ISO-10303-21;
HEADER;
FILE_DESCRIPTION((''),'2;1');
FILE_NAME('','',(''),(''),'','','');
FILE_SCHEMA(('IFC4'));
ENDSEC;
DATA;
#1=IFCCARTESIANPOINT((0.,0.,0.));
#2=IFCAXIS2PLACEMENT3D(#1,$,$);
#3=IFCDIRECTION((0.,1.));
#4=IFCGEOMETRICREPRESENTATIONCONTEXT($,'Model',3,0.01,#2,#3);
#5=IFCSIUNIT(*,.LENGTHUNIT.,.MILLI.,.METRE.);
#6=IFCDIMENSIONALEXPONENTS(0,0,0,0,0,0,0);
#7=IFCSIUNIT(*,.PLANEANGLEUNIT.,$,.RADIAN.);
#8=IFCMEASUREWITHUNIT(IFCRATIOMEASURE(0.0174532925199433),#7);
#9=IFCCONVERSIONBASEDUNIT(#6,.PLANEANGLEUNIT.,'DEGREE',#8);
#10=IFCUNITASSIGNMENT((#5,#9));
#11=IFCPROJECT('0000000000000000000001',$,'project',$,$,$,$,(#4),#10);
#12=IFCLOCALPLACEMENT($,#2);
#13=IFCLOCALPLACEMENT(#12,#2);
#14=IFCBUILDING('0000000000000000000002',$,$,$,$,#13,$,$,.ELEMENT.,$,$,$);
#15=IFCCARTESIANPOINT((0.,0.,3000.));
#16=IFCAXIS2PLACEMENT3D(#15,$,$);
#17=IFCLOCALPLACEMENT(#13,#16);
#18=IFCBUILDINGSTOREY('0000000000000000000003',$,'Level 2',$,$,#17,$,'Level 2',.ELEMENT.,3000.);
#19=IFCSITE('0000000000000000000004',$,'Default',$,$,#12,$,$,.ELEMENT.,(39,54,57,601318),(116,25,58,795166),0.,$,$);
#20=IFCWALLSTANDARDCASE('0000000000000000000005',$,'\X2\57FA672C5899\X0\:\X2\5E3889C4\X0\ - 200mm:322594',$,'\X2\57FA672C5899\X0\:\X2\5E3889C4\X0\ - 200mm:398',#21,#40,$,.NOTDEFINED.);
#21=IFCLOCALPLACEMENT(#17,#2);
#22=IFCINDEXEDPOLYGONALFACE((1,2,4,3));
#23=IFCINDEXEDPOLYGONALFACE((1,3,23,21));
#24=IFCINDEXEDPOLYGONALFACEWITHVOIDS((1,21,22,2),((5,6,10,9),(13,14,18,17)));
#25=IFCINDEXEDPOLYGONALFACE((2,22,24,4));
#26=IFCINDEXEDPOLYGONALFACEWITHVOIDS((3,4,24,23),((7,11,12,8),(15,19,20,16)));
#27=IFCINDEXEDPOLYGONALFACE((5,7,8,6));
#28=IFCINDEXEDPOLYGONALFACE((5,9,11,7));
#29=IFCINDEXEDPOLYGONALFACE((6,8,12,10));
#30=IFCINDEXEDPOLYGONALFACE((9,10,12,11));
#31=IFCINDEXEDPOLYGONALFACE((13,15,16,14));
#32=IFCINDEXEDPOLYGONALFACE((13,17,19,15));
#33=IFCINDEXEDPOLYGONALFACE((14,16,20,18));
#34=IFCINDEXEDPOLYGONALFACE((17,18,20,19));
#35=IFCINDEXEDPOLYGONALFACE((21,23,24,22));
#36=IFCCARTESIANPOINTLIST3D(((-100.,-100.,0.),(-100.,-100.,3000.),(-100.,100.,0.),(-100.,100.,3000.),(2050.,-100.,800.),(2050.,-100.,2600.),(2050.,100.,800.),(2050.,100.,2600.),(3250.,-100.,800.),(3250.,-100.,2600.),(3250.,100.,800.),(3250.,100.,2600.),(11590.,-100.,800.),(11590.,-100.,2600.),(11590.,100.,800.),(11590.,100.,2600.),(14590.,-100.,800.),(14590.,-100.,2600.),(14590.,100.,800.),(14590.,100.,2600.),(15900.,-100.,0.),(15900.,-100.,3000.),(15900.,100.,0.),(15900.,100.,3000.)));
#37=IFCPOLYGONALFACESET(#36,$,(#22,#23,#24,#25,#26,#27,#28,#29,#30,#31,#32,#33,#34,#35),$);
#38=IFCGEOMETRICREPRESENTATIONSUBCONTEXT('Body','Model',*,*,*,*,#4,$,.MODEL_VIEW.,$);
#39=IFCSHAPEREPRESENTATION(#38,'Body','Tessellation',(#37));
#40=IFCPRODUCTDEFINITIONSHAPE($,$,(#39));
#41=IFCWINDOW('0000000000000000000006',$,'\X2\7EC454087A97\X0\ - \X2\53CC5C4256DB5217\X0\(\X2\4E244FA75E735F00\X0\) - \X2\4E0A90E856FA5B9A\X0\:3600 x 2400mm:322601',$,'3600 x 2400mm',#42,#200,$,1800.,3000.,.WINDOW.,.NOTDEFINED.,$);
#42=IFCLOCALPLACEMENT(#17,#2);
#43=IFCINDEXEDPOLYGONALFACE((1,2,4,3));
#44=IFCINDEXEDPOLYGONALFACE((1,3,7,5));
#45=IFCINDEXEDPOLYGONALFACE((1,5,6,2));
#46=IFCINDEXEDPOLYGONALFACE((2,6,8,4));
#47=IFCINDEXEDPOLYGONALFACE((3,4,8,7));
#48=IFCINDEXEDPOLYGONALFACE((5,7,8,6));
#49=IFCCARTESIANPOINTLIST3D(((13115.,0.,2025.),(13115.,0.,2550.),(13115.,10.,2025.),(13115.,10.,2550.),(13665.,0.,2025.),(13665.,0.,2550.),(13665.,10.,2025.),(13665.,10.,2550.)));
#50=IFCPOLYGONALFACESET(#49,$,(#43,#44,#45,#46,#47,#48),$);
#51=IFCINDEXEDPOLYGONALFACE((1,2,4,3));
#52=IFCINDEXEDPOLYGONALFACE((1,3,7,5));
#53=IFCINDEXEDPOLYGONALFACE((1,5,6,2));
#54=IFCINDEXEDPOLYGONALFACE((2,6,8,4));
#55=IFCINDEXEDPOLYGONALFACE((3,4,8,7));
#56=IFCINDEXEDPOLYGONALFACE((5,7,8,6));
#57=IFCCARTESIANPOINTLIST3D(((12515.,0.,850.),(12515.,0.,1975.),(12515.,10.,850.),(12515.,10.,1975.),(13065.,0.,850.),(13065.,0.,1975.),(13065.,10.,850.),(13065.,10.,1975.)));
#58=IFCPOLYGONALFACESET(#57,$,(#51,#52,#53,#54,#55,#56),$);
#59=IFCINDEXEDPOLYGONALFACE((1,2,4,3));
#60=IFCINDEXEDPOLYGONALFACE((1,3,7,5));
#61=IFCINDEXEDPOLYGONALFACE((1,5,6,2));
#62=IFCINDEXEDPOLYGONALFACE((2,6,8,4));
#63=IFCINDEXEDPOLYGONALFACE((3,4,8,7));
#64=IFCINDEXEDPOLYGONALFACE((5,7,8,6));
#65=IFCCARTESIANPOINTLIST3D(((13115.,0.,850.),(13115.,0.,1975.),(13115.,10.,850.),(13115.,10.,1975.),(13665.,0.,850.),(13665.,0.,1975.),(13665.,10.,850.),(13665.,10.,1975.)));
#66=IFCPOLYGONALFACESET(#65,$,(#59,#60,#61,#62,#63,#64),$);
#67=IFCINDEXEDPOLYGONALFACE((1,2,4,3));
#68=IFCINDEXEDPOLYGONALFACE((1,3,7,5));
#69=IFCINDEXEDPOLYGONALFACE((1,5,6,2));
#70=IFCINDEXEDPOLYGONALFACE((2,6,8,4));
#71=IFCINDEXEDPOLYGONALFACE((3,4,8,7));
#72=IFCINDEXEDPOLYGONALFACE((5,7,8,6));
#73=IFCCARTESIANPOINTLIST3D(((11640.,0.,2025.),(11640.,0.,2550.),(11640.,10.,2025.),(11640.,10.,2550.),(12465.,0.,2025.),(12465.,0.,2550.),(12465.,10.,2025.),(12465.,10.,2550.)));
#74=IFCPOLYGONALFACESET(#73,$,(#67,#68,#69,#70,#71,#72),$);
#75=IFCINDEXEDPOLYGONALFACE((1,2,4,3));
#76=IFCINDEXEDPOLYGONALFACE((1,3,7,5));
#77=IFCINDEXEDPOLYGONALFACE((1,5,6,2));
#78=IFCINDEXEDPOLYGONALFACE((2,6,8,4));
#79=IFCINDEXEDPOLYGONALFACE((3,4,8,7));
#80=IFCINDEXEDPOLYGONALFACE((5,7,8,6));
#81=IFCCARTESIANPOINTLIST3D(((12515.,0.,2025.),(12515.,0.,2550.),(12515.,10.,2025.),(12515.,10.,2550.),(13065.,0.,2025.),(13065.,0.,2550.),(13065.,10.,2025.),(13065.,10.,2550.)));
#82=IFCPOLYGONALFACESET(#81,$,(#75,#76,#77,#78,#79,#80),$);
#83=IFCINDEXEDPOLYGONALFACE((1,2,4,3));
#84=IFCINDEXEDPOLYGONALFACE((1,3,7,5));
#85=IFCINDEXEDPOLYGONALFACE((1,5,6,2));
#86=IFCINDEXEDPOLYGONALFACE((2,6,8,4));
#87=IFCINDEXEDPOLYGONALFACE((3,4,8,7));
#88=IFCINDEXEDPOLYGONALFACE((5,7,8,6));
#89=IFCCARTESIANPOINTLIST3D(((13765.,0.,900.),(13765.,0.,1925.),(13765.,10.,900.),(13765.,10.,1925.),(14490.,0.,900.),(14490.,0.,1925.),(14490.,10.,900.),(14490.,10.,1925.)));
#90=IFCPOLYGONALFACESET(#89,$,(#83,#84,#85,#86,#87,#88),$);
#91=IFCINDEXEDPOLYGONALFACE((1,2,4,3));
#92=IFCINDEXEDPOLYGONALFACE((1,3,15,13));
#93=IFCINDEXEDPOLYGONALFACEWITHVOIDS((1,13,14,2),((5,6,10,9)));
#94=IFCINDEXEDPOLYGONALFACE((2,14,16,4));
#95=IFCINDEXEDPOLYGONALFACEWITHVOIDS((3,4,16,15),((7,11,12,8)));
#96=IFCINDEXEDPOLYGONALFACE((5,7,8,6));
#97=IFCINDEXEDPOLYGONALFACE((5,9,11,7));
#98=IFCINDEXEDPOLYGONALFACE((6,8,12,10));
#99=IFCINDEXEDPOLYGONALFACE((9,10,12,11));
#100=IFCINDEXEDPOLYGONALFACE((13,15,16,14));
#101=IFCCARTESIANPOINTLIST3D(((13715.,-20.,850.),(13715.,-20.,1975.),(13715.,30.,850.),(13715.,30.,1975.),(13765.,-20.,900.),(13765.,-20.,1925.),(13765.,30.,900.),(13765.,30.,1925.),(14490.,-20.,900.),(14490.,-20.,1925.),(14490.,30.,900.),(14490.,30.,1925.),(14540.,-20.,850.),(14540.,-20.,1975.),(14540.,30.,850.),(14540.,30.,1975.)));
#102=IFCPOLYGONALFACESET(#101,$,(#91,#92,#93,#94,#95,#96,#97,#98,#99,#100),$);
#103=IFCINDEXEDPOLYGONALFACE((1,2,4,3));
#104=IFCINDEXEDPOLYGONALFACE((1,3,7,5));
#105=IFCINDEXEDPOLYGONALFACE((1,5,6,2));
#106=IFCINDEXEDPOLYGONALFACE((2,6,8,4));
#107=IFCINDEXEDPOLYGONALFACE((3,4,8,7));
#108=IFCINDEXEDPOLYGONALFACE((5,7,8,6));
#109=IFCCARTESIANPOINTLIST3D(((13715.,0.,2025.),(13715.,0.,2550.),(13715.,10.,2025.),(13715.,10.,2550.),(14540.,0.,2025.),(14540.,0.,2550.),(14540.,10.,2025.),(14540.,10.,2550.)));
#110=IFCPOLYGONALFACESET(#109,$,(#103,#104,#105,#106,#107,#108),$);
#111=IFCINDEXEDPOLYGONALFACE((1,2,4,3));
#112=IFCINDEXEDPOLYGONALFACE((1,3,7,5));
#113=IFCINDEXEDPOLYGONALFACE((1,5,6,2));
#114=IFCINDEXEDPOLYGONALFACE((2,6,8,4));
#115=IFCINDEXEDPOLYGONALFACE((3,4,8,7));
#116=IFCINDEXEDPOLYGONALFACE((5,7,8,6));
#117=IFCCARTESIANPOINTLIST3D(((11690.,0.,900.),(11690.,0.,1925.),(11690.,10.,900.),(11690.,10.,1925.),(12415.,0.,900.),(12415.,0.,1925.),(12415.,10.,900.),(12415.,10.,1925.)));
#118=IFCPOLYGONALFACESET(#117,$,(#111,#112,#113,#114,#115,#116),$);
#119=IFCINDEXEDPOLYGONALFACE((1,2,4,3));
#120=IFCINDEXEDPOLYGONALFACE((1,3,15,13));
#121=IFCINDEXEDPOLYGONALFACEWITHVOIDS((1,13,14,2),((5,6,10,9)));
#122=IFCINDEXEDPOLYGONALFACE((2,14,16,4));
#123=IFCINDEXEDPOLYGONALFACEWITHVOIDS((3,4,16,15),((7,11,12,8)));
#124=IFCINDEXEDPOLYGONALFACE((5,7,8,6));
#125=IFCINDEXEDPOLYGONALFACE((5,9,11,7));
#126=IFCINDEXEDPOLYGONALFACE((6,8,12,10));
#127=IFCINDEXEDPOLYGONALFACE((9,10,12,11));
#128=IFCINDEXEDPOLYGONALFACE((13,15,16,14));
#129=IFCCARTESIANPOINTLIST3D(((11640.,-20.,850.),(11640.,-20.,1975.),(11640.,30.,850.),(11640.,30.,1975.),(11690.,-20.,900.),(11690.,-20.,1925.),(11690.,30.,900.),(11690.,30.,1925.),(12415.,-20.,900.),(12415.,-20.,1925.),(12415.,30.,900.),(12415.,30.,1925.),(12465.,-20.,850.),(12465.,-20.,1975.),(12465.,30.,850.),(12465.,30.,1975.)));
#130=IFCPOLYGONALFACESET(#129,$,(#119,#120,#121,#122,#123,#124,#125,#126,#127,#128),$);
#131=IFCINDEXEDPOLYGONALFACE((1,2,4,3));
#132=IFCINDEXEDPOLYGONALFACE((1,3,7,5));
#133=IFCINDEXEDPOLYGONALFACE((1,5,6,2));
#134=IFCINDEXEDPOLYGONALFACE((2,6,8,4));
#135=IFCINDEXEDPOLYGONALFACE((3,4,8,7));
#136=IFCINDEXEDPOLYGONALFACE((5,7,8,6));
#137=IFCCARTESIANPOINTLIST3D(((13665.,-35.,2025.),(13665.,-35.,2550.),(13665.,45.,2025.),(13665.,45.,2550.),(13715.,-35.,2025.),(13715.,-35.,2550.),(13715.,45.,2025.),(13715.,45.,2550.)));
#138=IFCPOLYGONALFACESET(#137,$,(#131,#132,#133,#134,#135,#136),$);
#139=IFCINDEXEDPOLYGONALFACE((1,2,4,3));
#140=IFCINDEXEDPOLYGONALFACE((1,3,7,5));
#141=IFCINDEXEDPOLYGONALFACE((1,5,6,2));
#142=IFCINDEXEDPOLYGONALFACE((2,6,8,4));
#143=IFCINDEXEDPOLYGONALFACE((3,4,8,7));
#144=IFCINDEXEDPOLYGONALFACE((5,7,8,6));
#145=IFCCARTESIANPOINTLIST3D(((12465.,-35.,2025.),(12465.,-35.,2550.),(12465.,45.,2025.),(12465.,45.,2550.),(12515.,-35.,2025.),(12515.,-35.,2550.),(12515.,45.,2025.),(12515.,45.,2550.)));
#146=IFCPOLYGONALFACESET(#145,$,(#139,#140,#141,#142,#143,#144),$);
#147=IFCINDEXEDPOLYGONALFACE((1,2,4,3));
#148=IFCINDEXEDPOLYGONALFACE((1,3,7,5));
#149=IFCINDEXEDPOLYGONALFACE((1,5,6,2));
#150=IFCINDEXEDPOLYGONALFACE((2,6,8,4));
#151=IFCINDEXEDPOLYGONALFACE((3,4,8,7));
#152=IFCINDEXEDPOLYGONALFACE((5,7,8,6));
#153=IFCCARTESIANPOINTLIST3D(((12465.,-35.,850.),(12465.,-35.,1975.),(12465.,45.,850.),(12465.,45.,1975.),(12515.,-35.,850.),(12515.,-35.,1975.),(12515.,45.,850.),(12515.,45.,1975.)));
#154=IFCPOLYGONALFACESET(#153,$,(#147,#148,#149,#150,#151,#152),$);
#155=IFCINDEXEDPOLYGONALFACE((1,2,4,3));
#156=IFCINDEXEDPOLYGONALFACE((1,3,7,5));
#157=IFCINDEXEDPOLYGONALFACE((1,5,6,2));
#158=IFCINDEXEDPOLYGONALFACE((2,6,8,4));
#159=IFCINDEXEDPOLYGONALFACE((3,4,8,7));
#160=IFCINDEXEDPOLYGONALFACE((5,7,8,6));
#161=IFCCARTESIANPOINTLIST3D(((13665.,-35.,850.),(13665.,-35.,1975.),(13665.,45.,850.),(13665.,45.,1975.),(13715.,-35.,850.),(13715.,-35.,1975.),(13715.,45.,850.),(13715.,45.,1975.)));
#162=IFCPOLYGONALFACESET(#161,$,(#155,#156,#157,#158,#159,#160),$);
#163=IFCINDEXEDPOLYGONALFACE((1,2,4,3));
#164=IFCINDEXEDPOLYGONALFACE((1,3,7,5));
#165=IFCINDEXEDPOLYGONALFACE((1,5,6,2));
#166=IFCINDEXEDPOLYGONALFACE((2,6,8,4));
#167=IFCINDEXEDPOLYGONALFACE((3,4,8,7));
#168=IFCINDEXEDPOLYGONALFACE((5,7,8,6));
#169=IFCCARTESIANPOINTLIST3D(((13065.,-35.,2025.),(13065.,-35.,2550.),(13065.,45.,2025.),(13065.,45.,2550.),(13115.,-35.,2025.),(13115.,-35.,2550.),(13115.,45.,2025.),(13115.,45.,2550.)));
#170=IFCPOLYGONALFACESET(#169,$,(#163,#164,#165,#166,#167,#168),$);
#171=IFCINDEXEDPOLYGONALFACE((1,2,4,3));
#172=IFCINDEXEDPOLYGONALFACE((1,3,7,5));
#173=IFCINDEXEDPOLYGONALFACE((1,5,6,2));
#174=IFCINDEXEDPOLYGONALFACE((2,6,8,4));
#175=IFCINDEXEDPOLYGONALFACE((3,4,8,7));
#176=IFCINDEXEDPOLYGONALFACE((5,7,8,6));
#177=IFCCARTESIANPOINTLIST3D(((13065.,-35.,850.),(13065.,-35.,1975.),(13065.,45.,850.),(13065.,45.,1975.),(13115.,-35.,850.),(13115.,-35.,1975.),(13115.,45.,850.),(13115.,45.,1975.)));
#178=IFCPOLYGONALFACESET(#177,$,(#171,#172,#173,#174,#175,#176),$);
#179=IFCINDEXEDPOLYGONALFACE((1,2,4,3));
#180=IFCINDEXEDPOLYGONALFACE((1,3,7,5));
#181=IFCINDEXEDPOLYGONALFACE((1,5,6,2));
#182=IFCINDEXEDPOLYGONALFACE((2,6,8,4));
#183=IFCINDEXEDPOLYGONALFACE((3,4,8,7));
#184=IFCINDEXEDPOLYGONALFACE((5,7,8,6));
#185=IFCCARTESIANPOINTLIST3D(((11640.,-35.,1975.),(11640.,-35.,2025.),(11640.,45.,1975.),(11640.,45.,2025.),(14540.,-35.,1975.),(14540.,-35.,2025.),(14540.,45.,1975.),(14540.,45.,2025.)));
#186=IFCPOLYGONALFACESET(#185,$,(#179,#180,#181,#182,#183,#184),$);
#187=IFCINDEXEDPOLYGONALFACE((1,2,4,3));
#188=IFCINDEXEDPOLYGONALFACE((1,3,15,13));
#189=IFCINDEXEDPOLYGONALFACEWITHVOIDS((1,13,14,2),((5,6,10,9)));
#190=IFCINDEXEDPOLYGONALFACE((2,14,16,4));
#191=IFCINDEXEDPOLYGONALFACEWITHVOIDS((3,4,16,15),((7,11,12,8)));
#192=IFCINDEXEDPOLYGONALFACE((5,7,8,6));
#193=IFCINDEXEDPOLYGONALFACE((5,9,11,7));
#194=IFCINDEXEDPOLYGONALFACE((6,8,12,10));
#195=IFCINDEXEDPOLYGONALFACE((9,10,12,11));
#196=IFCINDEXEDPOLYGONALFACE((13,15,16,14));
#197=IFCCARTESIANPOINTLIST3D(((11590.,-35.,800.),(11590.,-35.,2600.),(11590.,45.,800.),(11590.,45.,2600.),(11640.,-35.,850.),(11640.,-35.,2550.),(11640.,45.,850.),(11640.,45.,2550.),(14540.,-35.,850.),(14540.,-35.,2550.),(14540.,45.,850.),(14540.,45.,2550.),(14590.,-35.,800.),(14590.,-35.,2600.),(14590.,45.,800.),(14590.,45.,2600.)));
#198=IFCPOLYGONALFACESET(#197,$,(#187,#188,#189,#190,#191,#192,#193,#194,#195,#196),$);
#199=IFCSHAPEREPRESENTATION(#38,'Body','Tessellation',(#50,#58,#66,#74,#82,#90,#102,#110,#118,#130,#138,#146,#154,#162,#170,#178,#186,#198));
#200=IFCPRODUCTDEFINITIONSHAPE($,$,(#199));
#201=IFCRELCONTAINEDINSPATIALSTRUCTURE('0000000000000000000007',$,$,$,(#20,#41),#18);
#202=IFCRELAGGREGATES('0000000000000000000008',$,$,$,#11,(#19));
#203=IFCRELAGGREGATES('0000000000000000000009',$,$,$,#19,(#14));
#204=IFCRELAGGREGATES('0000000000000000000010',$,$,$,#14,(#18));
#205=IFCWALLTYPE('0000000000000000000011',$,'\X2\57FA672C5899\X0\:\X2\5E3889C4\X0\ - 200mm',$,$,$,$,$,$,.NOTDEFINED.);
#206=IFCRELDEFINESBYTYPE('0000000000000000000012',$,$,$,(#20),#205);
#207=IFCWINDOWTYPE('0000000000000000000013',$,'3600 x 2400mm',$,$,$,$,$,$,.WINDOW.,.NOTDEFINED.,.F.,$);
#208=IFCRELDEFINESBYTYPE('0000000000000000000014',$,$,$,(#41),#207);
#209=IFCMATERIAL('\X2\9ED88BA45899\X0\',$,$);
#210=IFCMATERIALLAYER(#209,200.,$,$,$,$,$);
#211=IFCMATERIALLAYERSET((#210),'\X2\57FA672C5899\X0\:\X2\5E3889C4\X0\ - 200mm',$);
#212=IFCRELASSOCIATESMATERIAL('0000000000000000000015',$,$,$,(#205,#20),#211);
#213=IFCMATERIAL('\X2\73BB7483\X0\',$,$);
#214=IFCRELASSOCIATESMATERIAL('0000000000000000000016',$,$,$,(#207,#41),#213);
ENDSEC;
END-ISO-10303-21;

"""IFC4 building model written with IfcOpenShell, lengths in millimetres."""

from ifc_helpers import new_model, entity, si_unit, converted_unit, direction, frame, frame_2d, origin, origin_2d_with_axis, place, context, subcontext, project, spatial, polyline, rectangle, outline, extrude, source, transform, mapped, material, layer, layer_set, layer_usage, type_object, type_shapes, element, fill, save


model = new_model("IFC4")

# Units and contexts
model_context = context("Model", 3, precision=0.01, world=origin(), true_north=direction((0.0, 1.0)))
body_context = subcontext(model_context, "Body", "Model", "MODEL_VIEW")
ifc_project = project(units=[si_unit("LENGTHUNIT", "METRE", prefix="MILLI"), converted_unit("PLANEANGLEUNIT", "DEGREE", entity("IfcRatioMeasure", 0.0174532925199433), si_unit("PLANEANGLEUNIT", "RADIAN"), dimensions=[0, 0, 0, 0, 0, 0, 0])], contexts=[model_context])

# Site, building, storey
site_placement = place(None, origin())
site = spatial("IfcSite", under=ifc_project, at=site_placement, Name="Default", CompositionType="ELEMENT", RefLatitude=(39, 54, 57, 601318), RefLongitude=(116, 25, 58, 795166), RefElevation=0.0)
building_placement = place(site_placement, origin())
building = spatial("IfcBuilding", under=site, at=building_placement, CompositionType="ELEMENT")
storey_placement = place(building_placement, frame((0.0, 0.0, 3000.0)))
storey = spatial("IfcBuildingStorey", under=building, at=storey_placement, Name="Level 2", LongName="Level 2", CompositionType="ELEMENT", Elevation=3000.0)

# Shared definitions
ifc_material_1 = material(Name="默认墙")
ifc_layer_1 = layer(ifc_material_1, 200.0)
ifc_layer_set_1 = layer_set([ifc_layer_1], Name="基本墙:常规 - 200mm")
wall_type = type_object("IfcWallType", Name="基本墙:常规 - 200mm", PredefinedType="NOTDEFINED", material=ifc_layer_set_1)

# Shared definitions
ifc_material_2 = material(Name="玻璃")

# Wall, openings, window
ifc_layer_usage_1 = layer_usage(ifc_layer_set_1, "AXIS2", "NEGATIVE", 100.0)
wall_1_placement = place(storey_placement, frame((15900.0, 0.0, 0.0), z_axis=(0.0, 0.0, 1.0), x_axis=(-1.0, 0.0, 0.0)))
wall_1 = element("IfcWallStandardCase", 1, at=wall_1_placement, inside=storey, type_object=wall_type, material=ifc_layer_usage_1, Name="基本墙:常规 - 200mm:322594", ObjectType="基本墙:常规 - 200mm:398", PredefinedType="NOTDEFINED", context=body_context, shape_type="SweptSolid", body=[
    extrude(rectangle(XDim=16000.0, YDim=200.0, at=frame_2d((8000.0, 0.0), x_axis=(-1.0, 0.0))), origin(), (0.0, 0.0, 1.0), 3000.0),
])
opening_1_placement = place(wall_1_placement, frame((12650.0, -100.0, 800.0)))
element("IfcOpeningElement", 2, at=opening_1_placement, cuts=wall_1, ObjectType="Opening", PredefinedType="OPENING", context=body_context, shape_type="SweptSolid", body=[
    extrude(rectangle(XDim=1800.0, YDim=1200.0, at=frame_2d((900.0, 600.0), x_axis=(1.0, 0.0))), frame((0.0, 0.0, 0.0), z_axis=(0.0, 1.0, 0.0), x_axis=(0.0, 0.0, 1.0)), (0.0, 0.0, 1.0), 200.0),
])
opening_2_placement = place(wall_1_placement, frame((1310.0, -100.0, 800.0)))
opening_2 = element("IfcOpeningElement", 3, at=opening_2_placement, cuts=wall_1, ObjectType="Opening", PredefinedType="OPENING", context=body_context, shape_type="SweptSolid", body=[
    extrude(rectangle(XDim=1800.0, YDim=3000.0, at=frame_2d((900.0, 1500.0), x_axis=(1.0, 0.0))), frame((0.0, 0.0, 0.0), z_axis=(0.0, 1.0, 0.0), x_axis=(0.0, 0.0, 1.0)), (0.0, 0.0, 1.0), 200.0),
])
window_type_1 = type_object("IfcWindowType", Name="3600 x 2400mm", ParameterTakesPrecedence=False, PartitioningType="NOTDEFINED", PredefinedType="WINDOW", material=ifc_material_2)
shared_shape_1 = source(origin(), body_context, "Body", "SweptSolid", [
    extrude(rectangle(XDim=10.0, YDim=550.0, at=origin_2d_with_axis()), frame((1200.0, 95.0, 1225.0), z_axis=(0.0, 0.0, 1.0), x_axis=(0.0, 1.0, 0.0)), (0.0, 0.0, 1.0), 525.0),
    extrude(rectangle(XDim=10.0, YDim=550.0, at=origin_2d_with_axis()), frame((1800.0, 95.0, 50.0), z_axis=(0.0, 0.0, 1.0), x_axis=(0.0, 1.0, 0.0)), (0.0, 0.0, 1.0), 1125.0),
    extrude(rectangle(XDim=10.0, YDim=550.0, at=origin_2d_with_axis()), frame((1200.0, 95.0, 50.0), z_axis=(0.0, 0.0, 1.0), x_axis=(0.0, 1.0, 0.0)), (0.0, 0.0, 1.0), 1125.0),
    extrude(rectangle(XDim=10.0, YDim=825.0, at=frame_2d((0.0, 0.0), x_axis=(1.0, 0.0))), frame((2537.5, 95.0, 1225.0), z_axis=(0.0, 0.0, 1.0), x_axis=(0.0, 1.0, 0.0)), (0.0, 0.0, 1.0), 525.0),
    extrude(rectangle(XDim=10.0, YDim=550.0, at=frame_2d((0.0, 0.0), x_axis=(1.0, 0.0))), frame((1800.0, 95.0, 1225.0), z_axis=(0.0, 0.0, 1.0), x_axis=(0.0, 1.0, 0.0)), (0.0, 0.0, 1.0), 525.0),
    extrude(rectangle(XDim=10.0, YDim=725.0, at=frame_2d((0.0, 0.0), x_axis=(1.0, 0.0))), frame((462.5, 95.0, 100.0), z_axis=(0.0, 0.0, 1.0), x_axis=(0.0, 1.0, 0.0)), (0.0, 0.0, 1.0), 1025.0),
    extrude(outline(polyline([(-562.5, -412.5), (562.5, -412.5), (562.5, 412.5), (-562.5, 412.5), (-562.5, -412.5)]), holes=[polyline([(512.5, -362.5), (-512.5, -362.5), (-512.5, 362.5), (512.5, 362.5), (512.5, -362.5)])]), frame((462.5, 70.0, 612.5), z_axis=(0.0, 1.0, 0.0), x_axis=(0.0, 0.0, -1.0)), (0.0, 0.0, 1.0), 50.0),
    extrude(rectangle(XDim=10.0, YDim=825.0, at=origin_2d_with_axis()), frame((462.5, 95.0, 1225.0), z_axis=(0.0, 0.0, 1.0), x_axis=(0.0, 1.0, 0.0)), (0.0, 0.0, 1.0), 525.0),
    extrude(rectangle(XDim=10.0, YDim=725.0, at=frame_2d((0.0, 0.0), x_axis=(1.0, 0.0))), frame((2537.5, 95.0, 100.0), z_axis=(0.0, 0.0, 1.0), x_axis=(0.0, 1.0, 0.0)), (0.0, 0.0, 1.0), 1025.0),
    extrude(outline(polyline([(-562.5, -412.5), (562.5, -412.5), (562.5, 412.5), (-562.5, 412.5), (-562.5, -412.5)]), holes=[polyline([(512.5, -362.5), (-512.5, -362.5), (-512.5, 362.5), (512.5, 362.5), (512.5, -362.5)])]), frame((2537.5, 70.0, 612.5), z_axis=(0.0, 1.0, 0.0), x_axis=(0.0, 0.0, -1.0)), (0.0, 0.0, 1.0), 50.0),
    extrude(rectangle(XDim=80.0, YDim=50.0, at=origin_2d_with_axis()), frame((900.0, 95.0, 1225.0), z_axis=(0.0, 0.0, 1.0), x_axis=(0.0, -1.0, 0.0)), (0.0, 0.0, 1.0), 525.0),
    extrude(rectangle(XDim=80.0, YDim=50.0, at=frame_2d((0.0, 0.0), x_axis=(1.0, 0.0))), frame((2100.0, 95.0, 1225.0), z_axis=(0.0, 0.0, 1.0), x_axis=(0.0, -1.0, 0.0)), (0.0, 0.0, 1.0), 525.0),
    extrude(rectangle(XDim=80.0, YDim=50.0, at=origin_2d_with_axis()), frame((2100.0, 95.0, 50.0), z_axis=(0.0, 0.0, 1.0), x_axis=(0.0, -1.0, 0.0)), (0.0, 0.0, 1.0), 1125.0),
    extrude(rectangle(XDim=80.0, YDim=50.0, at=origin_2d_with_axis()), frame((900.0, 95.0, 50.0), z_axis=(0.0, 0.0, 1.0), x_axis=(0.0, -1.0, 0.0)), (0.0, 0.0, 1.0), 1125.0),
    extrude(rectangle(XDim=80.0, YDim=50.0, at=frame_2d((0.0, 0.0), x_axis=(1.0, 0.0))), frame((1500.0, 95.0, 1225.0), z_axis=(0.0, 0.0, 1.0), x_axis=(0.0, -1.0, 0.0)), (0.0, 0.0, 1.0), 525.0),
    extrude(rectangle(XDim=80.0, YDim=50.0, at=origin_2d_with_axis()), frame((1500.0, 95.0, 50.0), z_axis=(0.0, 0.0, 1.0), x_axis=(0.0, -1.0, 0.0)), (0.0, 0.0, 1.0), 1125.0),
    extrude(rectangle(XDim=80.0, YDim=2900.0, at=frame_2d((0.0, 0.0), x_axis=(1.0, 0.0))), frame((1500.0, 95.0, 1175.0), z_axis=(0.0, 0.0, 1.0), x_axis=(0.0, -1.0, 0.0)), (0.0, 0.0, 1.0), 50.0),
    extrude(outline(polyline([(-1500.0, -900.0), (1500.0, -900.0), (1500.0, 900.0), (-1500.0, 900.0), (-1500.0, -900.0)]), holes=[polyline([(1450.0, -850.0), (-1450.0, -850.0), (-1450.0, 850.0), (1450.0, 850.0), (1450.0, -850.0)])]), frame((1500.0, 55.0, 900.0), z_axis=(0.0, 1.0, 0.0), x_axis=(1.0, 0.0, 0.0)), (0.0, 0.0, 1.0), 80.0),
])
type_shapes(window_type_1, [shared_shape_1])
window_1_placement = place(opening_2_placement, origin())
window_1 = element("IfcWindow", 4, at=window_1_placement, inside=storey, type_object=window_type_1, material=ifc_material_2, Name="组合窗 - 双层四列(两侧平开) - 上部固定:3600 x 2400mm:322601", ObjectType="3600 x 2400mm", OverallHeight=1800.0, OverallWidth=3000.0, PartitioningType="NOTDEFINED", PredefinedType="WINDOW", context=body_context, shape_type="MappedRepresentation", body=[
    mapped(shared_shape_1, transform((0.0, 0.0, 0.0), scale=1.0)),
])
fill(opening_2, window_1)

save(model, "model.ifc")
